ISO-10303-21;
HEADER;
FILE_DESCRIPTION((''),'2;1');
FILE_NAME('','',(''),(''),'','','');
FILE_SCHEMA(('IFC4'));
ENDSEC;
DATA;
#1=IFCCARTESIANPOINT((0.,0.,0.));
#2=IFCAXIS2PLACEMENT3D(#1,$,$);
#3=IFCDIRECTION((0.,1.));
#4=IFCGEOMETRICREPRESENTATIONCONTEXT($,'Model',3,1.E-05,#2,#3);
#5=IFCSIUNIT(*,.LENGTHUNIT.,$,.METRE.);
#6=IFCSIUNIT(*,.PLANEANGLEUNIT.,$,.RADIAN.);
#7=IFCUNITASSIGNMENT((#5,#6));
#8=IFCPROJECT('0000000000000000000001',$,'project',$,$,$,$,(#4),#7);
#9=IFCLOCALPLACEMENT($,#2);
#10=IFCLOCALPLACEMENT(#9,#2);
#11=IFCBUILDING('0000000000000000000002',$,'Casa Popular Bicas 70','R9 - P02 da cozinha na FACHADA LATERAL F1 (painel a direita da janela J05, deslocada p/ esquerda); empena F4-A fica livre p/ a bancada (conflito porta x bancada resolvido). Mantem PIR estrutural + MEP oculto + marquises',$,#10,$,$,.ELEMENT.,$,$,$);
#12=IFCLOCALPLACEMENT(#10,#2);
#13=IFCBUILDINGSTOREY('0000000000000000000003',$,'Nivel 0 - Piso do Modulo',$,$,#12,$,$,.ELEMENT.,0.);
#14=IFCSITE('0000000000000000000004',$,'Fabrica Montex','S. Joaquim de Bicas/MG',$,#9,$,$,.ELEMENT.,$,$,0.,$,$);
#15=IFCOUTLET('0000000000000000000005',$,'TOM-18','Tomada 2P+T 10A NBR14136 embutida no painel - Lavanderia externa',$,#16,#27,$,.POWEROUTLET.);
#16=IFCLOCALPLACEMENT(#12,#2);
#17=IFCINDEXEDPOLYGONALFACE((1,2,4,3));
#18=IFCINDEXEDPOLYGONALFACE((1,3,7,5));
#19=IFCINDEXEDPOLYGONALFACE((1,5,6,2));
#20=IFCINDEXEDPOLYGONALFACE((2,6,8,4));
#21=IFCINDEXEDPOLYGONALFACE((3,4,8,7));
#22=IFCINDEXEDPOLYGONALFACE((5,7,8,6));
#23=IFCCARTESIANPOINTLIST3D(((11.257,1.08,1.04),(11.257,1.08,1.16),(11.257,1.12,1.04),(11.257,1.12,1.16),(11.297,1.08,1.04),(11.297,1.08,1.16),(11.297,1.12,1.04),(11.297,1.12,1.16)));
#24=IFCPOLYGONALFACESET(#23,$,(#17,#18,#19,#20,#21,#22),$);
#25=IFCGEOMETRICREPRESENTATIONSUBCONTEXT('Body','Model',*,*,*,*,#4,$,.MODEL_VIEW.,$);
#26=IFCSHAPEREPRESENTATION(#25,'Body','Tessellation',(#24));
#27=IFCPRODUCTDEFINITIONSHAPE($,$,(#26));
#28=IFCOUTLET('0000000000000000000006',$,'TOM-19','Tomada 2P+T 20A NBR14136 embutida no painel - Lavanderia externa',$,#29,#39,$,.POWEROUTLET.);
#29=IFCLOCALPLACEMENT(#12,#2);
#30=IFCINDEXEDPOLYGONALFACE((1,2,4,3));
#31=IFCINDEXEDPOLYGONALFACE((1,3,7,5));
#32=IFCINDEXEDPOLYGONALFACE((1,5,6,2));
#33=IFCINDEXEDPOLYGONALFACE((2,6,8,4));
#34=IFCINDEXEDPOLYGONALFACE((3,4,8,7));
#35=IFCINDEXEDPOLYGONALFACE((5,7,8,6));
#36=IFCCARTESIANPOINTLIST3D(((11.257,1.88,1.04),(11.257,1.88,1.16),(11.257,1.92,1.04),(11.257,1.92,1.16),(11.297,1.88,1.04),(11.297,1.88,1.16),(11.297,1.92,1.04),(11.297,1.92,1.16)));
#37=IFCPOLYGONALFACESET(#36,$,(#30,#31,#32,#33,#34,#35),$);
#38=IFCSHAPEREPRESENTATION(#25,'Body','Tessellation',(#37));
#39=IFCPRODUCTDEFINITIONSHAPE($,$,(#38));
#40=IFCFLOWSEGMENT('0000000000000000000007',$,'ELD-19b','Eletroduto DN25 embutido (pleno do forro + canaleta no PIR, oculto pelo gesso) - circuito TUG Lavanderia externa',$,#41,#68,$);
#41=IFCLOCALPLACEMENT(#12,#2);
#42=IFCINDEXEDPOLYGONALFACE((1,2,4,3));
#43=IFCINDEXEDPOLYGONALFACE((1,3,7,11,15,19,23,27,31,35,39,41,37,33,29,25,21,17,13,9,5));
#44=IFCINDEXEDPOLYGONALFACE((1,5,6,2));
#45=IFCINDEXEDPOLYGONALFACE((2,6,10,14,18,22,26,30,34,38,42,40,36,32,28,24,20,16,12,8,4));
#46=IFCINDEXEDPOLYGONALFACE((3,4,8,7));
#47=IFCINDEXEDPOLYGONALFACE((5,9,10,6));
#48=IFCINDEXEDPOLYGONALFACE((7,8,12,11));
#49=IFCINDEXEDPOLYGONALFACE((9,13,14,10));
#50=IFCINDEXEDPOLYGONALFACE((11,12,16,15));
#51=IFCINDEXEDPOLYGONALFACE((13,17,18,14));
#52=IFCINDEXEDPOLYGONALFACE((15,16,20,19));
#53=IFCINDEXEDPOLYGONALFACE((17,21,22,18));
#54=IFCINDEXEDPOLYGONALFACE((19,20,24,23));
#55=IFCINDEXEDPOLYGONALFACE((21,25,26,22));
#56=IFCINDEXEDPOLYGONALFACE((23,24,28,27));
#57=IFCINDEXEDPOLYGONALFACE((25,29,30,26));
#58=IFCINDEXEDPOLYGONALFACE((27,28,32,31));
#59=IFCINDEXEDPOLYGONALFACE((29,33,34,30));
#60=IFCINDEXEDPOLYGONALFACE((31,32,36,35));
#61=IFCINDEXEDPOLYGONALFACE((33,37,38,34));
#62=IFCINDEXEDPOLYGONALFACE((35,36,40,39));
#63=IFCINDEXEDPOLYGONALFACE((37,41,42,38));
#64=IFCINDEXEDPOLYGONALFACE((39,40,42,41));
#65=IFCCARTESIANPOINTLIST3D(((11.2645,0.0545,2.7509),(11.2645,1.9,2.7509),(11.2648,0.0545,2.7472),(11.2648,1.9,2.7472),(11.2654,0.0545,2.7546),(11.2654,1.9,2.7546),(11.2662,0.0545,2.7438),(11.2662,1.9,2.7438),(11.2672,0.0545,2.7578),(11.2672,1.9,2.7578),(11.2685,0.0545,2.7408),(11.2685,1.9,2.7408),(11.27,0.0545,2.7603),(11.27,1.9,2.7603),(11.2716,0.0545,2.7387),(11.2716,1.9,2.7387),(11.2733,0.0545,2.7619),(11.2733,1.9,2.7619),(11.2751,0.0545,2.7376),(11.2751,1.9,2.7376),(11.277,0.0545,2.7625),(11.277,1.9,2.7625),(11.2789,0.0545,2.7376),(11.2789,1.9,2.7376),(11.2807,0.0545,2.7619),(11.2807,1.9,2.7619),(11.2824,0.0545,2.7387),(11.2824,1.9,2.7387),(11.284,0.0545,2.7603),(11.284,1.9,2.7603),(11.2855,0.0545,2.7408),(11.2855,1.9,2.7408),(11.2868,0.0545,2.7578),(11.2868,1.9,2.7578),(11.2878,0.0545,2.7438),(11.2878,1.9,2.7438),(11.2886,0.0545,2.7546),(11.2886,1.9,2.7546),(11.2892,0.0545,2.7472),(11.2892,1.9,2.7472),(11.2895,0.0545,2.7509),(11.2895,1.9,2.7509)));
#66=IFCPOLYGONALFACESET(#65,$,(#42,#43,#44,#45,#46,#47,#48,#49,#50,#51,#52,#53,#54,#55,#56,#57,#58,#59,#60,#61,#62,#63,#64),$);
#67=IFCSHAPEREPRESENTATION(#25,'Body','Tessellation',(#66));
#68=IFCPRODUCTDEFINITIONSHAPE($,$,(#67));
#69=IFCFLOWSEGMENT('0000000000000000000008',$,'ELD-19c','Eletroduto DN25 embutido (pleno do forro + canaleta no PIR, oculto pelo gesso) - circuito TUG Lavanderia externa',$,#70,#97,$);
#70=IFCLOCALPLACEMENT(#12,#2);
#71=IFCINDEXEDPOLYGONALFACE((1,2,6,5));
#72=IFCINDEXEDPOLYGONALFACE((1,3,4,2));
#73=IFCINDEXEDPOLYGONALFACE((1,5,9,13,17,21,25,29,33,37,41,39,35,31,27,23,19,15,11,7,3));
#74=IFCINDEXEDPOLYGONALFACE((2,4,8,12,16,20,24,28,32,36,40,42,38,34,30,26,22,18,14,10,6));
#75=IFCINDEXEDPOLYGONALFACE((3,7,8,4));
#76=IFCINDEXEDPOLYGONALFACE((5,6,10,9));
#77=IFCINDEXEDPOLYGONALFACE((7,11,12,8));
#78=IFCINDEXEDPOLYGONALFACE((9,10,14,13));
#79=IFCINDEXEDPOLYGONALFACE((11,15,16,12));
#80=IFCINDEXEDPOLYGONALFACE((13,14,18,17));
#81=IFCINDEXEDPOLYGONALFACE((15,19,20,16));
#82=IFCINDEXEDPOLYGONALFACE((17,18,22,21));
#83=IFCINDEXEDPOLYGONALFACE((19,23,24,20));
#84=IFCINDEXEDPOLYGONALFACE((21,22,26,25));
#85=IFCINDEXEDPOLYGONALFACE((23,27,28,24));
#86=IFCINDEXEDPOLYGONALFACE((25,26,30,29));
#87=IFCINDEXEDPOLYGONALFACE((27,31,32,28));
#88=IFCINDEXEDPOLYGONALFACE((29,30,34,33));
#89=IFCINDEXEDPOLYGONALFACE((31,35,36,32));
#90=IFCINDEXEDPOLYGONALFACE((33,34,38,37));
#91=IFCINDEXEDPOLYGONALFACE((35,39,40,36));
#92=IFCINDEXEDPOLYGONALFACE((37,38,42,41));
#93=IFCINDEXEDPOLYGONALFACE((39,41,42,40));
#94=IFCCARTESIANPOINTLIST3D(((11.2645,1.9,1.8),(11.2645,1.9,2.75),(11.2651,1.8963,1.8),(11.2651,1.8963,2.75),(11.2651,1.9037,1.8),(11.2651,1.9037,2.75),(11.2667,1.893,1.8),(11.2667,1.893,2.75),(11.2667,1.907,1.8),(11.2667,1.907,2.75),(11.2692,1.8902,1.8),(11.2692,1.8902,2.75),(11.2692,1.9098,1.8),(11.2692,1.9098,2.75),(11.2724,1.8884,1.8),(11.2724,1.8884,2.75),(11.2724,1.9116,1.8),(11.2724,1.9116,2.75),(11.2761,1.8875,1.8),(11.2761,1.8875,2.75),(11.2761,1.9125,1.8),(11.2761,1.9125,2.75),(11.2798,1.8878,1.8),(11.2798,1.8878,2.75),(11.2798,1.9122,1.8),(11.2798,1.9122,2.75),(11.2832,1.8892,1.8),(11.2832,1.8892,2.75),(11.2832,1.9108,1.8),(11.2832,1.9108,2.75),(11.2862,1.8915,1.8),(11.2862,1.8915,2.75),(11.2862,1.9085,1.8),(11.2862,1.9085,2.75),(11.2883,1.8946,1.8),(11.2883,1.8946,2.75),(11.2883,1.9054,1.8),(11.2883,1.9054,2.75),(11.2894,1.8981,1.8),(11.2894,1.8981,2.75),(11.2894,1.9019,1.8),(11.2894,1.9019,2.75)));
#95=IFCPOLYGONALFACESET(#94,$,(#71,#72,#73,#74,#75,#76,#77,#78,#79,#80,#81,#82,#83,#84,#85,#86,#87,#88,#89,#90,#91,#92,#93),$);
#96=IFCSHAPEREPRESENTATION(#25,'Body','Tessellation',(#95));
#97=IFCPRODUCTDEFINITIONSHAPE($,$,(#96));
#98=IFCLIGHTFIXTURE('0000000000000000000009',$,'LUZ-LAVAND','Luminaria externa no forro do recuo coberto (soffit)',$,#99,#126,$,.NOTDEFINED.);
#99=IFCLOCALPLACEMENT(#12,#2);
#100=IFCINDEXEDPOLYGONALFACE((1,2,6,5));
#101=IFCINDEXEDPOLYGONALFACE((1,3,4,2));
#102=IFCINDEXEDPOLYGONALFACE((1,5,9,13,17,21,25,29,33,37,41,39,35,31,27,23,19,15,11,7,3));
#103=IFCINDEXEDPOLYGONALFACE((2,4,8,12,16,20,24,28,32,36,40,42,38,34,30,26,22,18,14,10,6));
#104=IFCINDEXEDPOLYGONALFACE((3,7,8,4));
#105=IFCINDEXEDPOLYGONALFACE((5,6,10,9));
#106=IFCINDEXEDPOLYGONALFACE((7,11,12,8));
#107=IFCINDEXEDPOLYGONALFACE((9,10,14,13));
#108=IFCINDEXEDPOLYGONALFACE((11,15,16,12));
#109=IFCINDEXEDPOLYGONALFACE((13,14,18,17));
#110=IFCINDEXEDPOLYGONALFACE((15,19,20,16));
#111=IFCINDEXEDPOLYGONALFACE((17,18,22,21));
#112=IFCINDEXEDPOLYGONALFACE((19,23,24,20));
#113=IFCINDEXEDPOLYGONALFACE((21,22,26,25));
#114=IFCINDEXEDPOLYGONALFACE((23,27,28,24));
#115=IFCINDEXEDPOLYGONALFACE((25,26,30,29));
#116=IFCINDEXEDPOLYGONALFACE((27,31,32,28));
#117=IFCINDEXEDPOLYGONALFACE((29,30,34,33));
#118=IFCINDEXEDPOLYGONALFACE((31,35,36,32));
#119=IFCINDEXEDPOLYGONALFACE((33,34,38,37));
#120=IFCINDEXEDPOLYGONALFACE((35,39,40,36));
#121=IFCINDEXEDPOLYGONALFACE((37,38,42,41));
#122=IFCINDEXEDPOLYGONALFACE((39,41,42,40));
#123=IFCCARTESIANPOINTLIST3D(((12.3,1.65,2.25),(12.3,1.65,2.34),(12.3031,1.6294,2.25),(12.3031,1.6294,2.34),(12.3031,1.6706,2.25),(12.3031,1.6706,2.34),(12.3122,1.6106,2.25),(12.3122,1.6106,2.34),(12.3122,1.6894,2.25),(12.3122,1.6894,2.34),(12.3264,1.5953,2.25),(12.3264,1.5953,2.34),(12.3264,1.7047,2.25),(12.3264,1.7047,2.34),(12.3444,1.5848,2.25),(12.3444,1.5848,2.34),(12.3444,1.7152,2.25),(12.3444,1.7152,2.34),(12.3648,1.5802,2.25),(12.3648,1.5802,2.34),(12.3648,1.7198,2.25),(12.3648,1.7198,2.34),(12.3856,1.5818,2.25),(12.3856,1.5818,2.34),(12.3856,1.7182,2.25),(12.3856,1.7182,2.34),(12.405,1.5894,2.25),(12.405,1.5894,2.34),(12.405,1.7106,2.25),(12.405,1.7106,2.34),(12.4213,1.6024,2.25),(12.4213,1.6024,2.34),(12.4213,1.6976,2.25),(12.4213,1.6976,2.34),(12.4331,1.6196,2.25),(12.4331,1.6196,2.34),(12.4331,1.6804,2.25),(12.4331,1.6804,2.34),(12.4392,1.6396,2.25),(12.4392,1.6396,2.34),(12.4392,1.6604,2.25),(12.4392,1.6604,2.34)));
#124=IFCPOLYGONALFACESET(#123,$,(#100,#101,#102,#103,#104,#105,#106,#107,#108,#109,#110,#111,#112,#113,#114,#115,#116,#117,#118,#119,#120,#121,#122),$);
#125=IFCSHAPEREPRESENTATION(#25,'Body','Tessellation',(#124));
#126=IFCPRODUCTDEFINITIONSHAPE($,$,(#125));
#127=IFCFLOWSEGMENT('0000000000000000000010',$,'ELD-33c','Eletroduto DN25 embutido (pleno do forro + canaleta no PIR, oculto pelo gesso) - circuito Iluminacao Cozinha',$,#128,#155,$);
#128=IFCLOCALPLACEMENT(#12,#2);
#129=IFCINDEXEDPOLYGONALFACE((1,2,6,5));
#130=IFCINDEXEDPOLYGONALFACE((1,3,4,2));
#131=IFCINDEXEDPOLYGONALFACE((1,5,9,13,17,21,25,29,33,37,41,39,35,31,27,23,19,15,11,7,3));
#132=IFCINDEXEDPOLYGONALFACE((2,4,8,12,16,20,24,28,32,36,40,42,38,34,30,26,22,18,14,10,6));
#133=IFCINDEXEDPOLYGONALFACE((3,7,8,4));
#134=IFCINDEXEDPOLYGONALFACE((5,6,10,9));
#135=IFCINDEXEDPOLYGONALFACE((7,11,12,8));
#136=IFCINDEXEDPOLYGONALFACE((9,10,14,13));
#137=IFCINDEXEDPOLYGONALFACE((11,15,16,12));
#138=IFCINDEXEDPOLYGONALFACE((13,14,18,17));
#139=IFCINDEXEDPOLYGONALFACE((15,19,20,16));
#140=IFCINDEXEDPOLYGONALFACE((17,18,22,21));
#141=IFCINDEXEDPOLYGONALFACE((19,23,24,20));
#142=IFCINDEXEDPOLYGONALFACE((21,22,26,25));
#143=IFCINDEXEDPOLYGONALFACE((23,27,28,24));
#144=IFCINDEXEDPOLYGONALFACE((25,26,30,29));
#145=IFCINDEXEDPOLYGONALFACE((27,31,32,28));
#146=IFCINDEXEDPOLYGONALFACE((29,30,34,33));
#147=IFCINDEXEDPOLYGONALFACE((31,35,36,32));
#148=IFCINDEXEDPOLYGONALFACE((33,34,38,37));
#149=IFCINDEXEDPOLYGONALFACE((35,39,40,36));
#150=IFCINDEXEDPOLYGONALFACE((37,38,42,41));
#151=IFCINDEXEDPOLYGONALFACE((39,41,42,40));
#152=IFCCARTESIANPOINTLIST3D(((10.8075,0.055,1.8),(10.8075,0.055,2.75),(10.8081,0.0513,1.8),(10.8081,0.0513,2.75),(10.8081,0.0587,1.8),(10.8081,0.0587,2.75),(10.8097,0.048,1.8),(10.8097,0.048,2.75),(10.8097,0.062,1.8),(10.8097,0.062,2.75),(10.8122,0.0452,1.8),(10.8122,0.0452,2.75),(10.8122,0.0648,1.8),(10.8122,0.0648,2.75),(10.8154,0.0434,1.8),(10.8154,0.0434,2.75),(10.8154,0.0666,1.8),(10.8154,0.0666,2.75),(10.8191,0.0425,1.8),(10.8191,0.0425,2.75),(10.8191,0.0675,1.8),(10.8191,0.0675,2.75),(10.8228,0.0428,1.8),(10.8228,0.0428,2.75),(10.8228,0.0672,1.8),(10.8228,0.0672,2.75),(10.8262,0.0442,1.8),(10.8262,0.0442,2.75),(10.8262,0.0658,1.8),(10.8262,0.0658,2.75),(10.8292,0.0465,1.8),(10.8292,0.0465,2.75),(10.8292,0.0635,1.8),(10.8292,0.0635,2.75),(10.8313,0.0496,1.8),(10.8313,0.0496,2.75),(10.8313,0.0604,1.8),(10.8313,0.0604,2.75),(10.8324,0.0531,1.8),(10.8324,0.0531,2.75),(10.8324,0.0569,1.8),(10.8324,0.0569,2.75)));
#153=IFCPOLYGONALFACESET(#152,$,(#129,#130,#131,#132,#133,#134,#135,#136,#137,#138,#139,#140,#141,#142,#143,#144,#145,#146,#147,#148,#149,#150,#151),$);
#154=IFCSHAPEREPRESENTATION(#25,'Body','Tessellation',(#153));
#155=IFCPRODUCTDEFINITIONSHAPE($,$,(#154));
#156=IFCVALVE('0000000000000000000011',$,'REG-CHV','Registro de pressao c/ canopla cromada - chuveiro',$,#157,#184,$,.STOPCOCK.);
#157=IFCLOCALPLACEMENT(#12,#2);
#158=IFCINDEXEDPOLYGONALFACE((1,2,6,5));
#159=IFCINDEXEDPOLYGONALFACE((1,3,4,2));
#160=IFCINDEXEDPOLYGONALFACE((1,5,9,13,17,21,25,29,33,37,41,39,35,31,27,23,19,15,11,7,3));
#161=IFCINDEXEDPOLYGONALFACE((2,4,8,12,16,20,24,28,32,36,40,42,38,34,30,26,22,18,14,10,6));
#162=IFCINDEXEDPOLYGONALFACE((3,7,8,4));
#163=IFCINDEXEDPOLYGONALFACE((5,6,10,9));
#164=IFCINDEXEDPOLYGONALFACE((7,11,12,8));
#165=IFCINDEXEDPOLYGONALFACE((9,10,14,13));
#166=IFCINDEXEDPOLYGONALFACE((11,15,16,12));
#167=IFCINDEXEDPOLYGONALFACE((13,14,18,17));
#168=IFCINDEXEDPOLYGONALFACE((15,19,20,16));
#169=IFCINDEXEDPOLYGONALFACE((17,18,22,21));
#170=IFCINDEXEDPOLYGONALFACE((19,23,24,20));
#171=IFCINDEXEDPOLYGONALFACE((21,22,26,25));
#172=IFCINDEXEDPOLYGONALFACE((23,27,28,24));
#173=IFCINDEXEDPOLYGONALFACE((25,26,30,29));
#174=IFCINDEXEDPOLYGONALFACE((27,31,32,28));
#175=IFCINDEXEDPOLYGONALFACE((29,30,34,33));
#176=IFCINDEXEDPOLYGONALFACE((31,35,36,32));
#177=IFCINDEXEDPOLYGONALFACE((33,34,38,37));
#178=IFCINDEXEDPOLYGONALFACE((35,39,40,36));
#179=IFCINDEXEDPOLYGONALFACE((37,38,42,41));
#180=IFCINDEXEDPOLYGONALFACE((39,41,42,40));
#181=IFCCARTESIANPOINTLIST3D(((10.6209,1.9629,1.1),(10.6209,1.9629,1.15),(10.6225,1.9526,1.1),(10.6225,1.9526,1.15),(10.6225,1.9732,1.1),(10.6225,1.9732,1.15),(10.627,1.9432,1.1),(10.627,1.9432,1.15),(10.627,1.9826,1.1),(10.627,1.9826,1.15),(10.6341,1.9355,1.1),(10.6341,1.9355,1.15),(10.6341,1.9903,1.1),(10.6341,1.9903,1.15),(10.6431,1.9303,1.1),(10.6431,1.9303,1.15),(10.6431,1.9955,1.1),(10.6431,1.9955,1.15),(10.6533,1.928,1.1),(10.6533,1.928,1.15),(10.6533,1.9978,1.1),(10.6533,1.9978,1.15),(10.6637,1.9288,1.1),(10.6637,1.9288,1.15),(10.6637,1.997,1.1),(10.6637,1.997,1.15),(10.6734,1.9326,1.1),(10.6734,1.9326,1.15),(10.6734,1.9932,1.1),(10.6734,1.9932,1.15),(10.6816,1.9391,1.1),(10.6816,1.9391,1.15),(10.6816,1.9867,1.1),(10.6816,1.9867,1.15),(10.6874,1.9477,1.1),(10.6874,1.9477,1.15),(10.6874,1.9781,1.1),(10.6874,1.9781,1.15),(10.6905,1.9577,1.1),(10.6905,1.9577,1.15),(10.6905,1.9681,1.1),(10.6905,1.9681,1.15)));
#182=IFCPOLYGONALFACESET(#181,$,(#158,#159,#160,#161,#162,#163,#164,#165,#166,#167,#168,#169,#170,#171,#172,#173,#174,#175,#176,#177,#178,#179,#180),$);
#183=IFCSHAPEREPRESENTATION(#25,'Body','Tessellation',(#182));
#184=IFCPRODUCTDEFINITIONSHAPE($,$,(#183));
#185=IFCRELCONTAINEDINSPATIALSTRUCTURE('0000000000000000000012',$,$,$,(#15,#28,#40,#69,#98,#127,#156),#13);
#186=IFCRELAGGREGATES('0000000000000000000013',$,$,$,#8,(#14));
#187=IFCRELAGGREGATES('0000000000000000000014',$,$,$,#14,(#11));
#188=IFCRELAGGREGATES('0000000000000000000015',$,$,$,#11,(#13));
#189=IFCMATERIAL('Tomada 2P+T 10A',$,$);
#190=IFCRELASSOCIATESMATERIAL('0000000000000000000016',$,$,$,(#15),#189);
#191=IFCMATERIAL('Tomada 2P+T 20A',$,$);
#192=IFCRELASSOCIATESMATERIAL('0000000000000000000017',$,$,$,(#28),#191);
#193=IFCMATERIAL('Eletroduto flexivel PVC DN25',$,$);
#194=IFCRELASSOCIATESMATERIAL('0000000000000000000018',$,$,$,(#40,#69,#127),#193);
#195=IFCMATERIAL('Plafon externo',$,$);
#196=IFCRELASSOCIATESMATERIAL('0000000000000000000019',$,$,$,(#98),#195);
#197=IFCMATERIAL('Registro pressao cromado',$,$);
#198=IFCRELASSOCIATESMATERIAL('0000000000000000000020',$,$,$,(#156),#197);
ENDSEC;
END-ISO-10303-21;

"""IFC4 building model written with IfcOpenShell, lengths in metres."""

from ifc_helpers import new_model, si_unit, direction, frame, frame_2d, origin, origin_2d, place, context, subcontext, project, spatial, rectangle, circle, extrude, material, element, save


model = new_model("IFC4")

# Units and contexts
model_context = context("Model", 3, precision=1e-05, world=origin(), true_north=direction((0.0, 1.0)))
body_context = subcontext(model_context, "Body", "Model", "MODEL_VIEW")
ifc_project = project(units=[si_unit("LENGTHUNIT", "METRE"), si_unit("PLANEANGLEUNIT", "RADIAN")], contexts=[model_context])

# Site, building, storey
site_placement = place(None, origin())
site = spatial("IfcSite", under=ifc_project, at=site_placement, Name="Fabrica Montex", Description="S. Joaquim de Bicas/MG", CompositionType="ELEMENT", RefElevation=0.0)
building_placement = place(site_placement, origin())
building = spatial("IfcBuilding", under=site, at=building_placement, Name="Casa Popular Bicas 70", Description="R9 - P02 da cozinha na FACHADA LATERAL F1 (painel a direita da janela J05, deslocada p/ esquerda); empena F4-A fica livre p/ a bancada (conflito porta x bancada resolvido). Mantem PIR estrutural + MEP oculto + marquises", CompositionType="ELEMENT")
storey_placement = place(building_placement, origin())
storey = spatial("IfcBuildingStorey", under=building, at=storey_placement, Name="Nivel 0 - Piso do Modulo", CompositionType="ELEMENT", Elevation=0.0)

# Shared definitions
ifc_material_1 = material(Name="Eletroduto flexivel PVC DN25")

# Shared definitions
ifc_material_2 = material(Name="Tomada 2P+T 10A")

# Outlet
outlet_1_placement = place(None, frame((11.297, 1.12, 1.04), z_axis=(0.0, 0.0, 1.0), x_axis=(-1.0, 0.0, 0.0)))
element("IfcOutlet", 1, at=outlet_1_placement, inside=storey, material=ifc_material_2, Name="TOM-18", Description="Tomada 2P+T 10A NBR14136 embutida no painel - Lavanderia externa", PredefinedType="POWEROUTLET", context=body_context, shape_type="SweptSolid", body=[
    extrude(rectangle(XDim=0.04, YDim=0.04, at=frame_2d((0.02, 0.02))), origin(), (0.0, 0.0, 1.0), 0.12),
])

# Outlet
ifc_material_3 = material(Name="Tomada 2P+T 20A")
outlet_2_placement = place(None, frame((11.297, 1.92, 1.04), z_axis=(0.0, 0.0, 1.0), x_axis=(-1.0, 0.0, 0.0)))
element("IfcOutlet", 2, at=outlet_2_placement, inside=storey, material=ifc_material_3, Name="TOM-19", Description="Tomada 2P+T 20A NBR14136 embutida no painel - Lavanderia externa", PredefinedType="POWEROUTLET", context=body_context, shape_type="SweptSolid", body=[
    extrude(rectangle(XDim=0.04, YDim=0.04, at=frame_2d((0.02, 0.02))), origin(), (0.0, 0.0, 1.0), 0.12),
])

# Flow segments
flow_segment_1_placement = place(None, frame((11.277, 0.0545, 2.75), z_axis=(0.0, 1.0, 0.0), x_axis=(0.0, 0.0, 1.0)))
element("IfcFlowSegment", 3, at=flow_segment_1_placement, inside=storey, material=ifc_material_1, Name="ELD-19b", Description="Eletroduto DN25 embutido (pleno do forro + canaleta no PIR, oculto pelo gesso) - circuito TUG Lavanderia externa", context=body_context, shape_type="SweptSolid", body=[
    extrude(circle(Radius=0.0125, at=origin_2d()), origin(), (0.0, 0.0, 1.0), 1.8455),
])
flow_segment_2_placement = place(None, frame((11.277, 1.9, 2.75), z_axis=(0.0, 0.0, -1.0), x_axis=(-1.0, 0.0, 0.0)))
element("IfcFlowSegment", 4, at=flow_segment_2_placement, inside=storey, material=ifc_material_1, Name="ELD-19c", Description="Eletroduto DN25 embutido (pleno do forro + canaleta no PIR, oculto pelo gesso) - circuito TUG Lavanderia externa", context=body_context, shape_type="SweptSolid", body=[
    extrude(circle(Radius=0.0125, at=origin_2d()), origin(), (0.0, 0.0, 1.0), 0.95),
])

# Light fixture
ifc_material_4 = material(Name="Plafon externo")
light_fixture_placement = place(None, frame((12.37, 1.65, 2.25), z_axis=(0.0, 0.0, 1.0), x_axis=(-1.0, 0.0, 0.0)))
element("IfcLightFixture", 5, at=light_fixture_placement, inside=storey, material=ifc_material_4, Name="LUZ-LAVAND", Description="Luminaria externa no forro do recuo coberto (soffit)", PredefinedType="NOTDEFINED", context=body_context, shape_type="SweptSolid", body=[
    extrude(circle(Radius=0.07, at=origin_2d()), origin(), (0.0, 0.0, 1.0), 0.09),
])

# Flow segment
flow_segment_3_placement = place(None, frame((10.82, 0.055, 2.75), z_axis=(0.0, 0.0, -1.0), x_axis=(-1.0, 0.0, 0.0)))
element("IfcFlowSegment", 6, at=flow_segment_3_placement, inside=storey, material=ifc_material_1, Name="ELD-33c", Description="Eletroduto DN25 embutido (pleno do forro + canaleta no PIR, oculto pelo gesso) - circuito Iluminacao Cozinha", context=body_context, shape_type="SweptSolid", body=[
    extrude(circle(Radius=0.0125, at=origin_2d()), origin(), (0.0, 0.0, 1.0), 0.95),
])

# Valve
ifc_material_5 = material(Name="Registro pressao cromado")
valve_placement = place(None, frame((10.6559, 1.9629, 1.1), z_axis=(0.0, 0.0, 1.0), x_axis=(-1.0, 0.0, 0.0)))
element("IfcValve", 7, at=valve_placement, inside=storey, material=ifc_material_5, Name="REG-CHV", Description="Registro de pressao c/ canopla cromada - chuveiro", PredefinedType="STOPCOCK", context=body_context, shape_type="SweptSolid", body=[
    extrude(circle(Radius=0.035, at=origin_2d()), origin(), (0.0, 0.0, 1.0), 0.05),
])

save(model, "model.ifc")
